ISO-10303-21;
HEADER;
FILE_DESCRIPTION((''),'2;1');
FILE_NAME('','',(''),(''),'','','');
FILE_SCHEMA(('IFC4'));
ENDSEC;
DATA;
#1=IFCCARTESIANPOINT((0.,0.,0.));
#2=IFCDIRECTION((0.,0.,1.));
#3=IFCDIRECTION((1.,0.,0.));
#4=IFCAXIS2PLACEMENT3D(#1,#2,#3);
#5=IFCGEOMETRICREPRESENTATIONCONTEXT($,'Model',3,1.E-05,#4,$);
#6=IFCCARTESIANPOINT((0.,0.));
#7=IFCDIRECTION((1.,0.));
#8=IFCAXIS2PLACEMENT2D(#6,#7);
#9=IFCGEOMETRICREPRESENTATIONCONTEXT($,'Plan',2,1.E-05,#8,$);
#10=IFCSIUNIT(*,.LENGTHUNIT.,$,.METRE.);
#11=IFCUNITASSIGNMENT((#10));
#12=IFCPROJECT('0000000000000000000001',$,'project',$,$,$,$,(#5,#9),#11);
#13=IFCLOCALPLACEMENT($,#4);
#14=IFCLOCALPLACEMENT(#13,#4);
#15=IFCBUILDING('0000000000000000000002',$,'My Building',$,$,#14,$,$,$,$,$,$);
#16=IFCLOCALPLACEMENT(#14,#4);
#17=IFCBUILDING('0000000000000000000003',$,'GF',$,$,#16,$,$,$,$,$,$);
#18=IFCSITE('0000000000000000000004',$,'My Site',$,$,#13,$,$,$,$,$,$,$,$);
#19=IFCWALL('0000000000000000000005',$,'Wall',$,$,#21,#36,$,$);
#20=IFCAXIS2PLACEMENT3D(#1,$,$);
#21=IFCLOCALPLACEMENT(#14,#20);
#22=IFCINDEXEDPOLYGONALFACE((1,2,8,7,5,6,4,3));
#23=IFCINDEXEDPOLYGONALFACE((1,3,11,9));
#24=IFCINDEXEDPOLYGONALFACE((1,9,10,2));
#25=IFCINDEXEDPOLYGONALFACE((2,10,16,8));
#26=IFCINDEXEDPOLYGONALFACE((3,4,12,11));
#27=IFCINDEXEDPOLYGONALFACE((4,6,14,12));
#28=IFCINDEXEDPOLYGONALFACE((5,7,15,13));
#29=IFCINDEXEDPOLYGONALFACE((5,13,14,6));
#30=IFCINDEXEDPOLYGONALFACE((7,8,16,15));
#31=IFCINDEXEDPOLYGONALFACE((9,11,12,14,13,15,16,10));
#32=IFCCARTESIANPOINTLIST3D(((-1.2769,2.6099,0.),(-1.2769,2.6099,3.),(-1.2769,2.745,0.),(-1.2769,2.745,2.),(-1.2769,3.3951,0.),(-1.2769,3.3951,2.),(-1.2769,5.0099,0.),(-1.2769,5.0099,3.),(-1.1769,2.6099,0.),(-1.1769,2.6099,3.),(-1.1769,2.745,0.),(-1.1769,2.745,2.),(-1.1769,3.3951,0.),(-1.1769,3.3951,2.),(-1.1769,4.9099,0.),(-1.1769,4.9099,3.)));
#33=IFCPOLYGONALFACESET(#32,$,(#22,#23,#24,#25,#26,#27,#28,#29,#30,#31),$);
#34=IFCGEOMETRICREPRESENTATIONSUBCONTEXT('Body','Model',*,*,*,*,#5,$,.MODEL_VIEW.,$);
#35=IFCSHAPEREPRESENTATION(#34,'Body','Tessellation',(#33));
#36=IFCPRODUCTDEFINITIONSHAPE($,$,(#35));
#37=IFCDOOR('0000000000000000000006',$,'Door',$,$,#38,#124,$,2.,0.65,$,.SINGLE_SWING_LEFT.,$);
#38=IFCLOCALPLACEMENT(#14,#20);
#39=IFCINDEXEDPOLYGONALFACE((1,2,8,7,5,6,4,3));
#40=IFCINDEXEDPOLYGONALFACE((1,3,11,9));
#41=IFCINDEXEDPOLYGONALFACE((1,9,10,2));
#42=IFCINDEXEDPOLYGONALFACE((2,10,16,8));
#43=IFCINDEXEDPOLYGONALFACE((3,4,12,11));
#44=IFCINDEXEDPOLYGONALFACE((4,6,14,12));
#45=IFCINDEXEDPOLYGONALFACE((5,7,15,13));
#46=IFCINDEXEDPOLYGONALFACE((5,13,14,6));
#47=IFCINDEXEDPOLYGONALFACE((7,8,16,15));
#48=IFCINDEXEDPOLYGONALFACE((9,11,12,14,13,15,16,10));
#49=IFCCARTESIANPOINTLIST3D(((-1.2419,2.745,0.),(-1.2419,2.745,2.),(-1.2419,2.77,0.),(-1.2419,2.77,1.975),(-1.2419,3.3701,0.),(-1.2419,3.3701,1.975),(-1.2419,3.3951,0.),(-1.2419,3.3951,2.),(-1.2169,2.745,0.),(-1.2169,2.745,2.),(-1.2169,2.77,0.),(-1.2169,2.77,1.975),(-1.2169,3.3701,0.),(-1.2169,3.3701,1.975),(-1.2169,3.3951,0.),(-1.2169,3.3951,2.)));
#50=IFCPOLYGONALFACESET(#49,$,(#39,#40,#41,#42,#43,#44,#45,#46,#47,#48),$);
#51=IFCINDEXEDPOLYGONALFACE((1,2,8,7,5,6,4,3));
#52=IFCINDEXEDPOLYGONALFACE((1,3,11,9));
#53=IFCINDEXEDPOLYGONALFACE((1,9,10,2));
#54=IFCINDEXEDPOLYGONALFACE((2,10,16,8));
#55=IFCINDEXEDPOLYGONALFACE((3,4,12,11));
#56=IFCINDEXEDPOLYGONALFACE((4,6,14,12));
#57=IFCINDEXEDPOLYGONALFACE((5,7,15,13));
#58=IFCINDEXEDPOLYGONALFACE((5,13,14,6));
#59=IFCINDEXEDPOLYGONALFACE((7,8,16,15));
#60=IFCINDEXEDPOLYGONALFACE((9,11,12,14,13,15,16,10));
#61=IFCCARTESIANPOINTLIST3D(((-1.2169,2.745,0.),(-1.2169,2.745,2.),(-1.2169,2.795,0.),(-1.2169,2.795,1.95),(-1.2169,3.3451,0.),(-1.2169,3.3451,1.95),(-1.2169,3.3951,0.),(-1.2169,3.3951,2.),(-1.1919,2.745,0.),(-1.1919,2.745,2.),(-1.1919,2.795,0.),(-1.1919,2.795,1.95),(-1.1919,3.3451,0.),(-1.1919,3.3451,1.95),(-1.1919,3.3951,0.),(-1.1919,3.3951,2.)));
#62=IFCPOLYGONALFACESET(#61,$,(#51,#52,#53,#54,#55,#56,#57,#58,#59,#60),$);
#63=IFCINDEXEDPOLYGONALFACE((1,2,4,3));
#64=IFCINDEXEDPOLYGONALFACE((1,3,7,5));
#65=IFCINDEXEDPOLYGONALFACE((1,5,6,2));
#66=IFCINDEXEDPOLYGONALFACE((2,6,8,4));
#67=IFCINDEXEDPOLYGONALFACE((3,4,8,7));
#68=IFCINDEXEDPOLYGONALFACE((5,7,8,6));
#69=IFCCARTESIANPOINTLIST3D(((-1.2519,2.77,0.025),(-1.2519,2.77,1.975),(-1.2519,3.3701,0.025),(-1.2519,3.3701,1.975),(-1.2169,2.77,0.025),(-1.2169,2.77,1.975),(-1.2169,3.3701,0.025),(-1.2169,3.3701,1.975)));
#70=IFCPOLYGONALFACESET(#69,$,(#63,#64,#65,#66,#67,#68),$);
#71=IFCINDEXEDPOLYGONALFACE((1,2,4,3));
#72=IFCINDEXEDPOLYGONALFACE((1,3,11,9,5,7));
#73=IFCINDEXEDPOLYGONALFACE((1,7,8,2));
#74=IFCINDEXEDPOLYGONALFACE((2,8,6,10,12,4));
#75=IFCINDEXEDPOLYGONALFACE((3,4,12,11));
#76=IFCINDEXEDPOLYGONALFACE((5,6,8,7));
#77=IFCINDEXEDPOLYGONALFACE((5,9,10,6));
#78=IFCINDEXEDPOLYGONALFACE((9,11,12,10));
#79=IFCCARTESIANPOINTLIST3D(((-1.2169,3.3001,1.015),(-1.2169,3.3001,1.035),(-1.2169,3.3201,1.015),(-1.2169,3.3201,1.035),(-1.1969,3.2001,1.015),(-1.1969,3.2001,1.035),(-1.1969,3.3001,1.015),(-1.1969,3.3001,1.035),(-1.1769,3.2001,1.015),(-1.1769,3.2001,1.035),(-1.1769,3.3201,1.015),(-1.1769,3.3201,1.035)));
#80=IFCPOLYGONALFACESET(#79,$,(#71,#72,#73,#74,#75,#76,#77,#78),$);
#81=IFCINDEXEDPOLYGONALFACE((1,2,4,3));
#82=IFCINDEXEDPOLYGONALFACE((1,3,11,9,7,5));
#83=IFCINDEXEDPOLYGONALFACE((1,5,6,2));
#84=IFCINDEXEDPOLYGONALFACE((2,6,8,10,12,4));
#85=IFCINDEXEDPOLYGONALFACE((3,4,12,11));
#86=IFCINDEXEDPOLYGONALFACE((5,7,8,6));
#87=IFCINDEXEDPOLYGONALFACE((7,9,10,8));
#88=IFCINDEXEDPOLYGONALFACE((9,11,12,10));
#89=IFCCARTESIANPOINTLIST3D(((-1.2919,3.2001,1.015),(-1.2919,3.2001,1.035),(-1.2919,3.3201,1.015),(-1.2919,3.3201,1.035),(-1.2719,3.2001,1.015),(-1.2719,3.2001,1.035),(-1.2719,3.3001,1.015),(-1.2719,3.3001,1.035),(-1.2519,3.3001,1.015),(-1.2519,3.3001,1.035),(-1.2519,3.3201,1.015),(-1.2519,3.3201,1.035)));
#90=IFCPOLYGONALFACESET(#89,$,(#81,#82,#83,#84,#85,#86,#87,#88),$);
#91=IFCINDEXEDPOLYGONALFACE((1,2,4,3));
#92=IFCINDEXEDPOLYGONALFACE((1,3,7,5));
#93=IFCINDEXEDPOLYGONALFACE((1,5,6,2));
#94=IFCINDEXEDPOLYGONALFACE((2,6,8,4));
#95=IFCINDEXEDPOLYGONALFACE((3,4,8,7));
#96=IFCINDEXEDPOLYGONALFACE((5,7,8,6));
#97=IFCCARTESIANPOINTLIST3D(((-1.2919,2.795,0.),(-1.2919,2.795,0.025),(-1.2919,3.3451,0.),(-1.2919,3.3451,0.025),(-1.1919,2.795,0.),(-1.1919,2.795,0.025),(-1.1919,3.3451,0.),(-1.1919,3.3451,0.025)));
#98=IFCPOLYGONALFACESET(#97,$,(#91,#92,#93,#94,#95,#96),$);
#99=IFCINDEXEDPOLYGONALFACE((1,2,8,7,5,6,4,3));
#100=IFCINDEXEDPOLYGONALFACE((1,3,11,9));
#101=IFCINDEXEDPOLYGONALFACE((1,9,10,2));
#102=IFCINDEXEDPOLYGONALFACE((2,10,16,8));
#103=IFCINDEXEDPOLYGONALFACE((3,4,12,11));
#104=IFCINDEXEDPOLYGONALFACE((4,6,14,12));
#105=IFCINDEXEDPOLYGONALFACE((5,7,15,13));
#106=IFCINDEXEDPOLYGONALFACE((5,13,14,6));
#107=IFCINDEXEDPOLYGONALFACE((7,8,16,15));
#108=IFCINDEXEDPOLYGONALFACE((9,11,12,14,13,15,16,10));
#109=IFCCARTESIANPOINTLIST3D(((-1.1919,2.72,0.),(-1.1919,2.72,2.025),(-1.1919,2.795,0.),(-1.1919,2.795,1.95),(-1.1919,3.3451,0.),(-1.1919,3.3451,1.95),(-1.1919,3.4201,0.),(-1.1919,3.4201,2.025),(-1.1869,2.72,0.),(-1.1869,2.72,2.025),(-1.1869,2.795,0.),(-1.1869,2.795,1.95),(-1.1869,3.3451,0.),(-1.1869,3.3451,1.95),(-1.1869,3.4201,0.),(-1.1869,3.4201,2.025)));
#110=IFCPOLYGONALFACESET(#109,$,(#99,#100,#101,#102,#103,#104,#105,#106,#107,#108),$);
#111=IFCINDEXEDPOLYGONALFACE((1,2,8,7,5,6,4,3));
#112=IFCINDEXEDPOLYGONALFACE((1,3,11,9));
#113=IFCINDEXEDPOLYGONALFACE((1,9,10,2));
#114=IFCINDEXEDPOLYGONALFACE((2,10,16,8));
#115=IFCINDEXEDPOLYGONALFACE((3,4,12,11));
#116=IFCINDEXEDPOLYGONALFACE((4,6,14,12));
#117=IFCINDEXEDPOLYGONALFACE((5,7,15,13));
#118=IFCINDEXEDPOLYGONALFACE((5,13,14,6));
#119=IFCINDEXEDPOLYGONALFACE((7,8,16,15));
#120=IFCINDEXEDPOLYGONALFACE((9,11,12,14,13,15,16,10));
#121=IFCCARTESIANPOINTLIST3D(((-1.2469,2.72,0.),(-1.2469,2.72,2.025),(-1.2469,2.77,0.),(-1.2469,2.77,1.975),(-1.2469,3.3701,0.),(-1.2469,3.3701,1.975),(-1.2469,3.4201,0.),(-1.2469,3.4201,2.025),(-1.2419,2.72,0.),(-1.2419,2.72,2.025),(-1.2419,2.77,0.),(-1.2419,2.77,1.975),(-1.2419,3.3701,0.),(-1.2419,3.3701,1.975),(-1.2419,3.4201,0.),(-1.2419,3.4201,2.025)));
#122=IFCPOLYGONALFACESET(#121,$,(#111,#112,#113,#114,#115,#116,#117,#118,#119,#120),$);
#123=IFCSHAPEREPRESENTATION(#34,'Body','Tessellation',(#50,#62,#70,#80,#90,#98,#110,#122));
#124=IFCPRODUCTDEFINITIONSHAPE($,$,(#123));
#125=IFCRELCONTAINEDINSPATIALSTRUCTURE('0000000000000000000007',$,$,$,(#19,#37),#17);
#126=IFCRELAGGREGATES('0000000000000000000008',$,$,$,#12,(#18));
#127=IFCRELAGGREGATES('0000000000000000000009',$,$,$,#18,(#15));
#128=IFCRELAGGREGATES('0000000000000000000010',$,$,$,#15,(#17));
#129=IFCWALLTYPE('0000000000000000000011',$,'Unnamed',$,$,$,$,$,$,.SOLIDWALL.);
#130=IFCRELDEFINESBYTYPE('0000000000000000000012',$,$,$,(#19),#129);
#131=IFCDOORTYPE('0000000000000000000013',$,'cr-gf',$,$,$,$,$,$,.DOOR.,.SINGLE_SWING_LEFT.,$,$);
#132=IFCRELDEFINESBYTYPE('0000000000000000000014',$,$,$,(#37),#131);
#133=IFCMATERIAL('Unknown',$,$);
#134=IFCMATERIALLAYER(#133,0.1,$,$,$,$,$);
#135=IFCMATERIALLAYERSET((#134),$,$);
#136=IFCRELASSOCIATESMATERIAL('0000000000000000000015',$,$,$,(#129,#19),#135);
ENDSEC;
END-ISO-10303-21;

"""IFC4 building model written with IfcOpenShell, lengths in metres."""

from ifc_helpers import new_model, entity, si_unit, frame, origin_with_axes, origin_2d_with_axis, place, context, subcontext, project, spatial, line, indexed_curve, outline, extrude, shape, source, transform, mapped, material, layer, layer_set, layer_usage, type_object, type_shapes, element, fill, save


model = new_model("IFC4")

# Units and contexts
model_context = context("Model", 3, precision=1e-05, world=origin_with_axes())
plan_context = context("Plan", 2, precision=1e-05, world=origin_2d_with_axis())
body_context_1 = subcontext(model_context, "Body", "Model", "MODEL_VIEW")
body_context_2 = subcontext(plan_context, "Body", "Plan", "PLAN_VIEW")
ifc_project = project(units=[si_unit("LENGTHUNIT", "METRE")], contexts=[model_context, plan_context])

# Site, buildings
site_placement = place(None, origin_with_axes())
site = spatial("IfcSite", under=ifc_project, at=site_placement, Name="My Site")
building_1_placement = place(site_placement, origin_with_axes())
building_1 = spatial("IfcBuilding", under=site, at=building_1_placement, Name="My Building")
building_2_placement = place(building_1_placement, origin_with_axes())
building_2 = spatial("IfcBuilding", under=building_1, at=building_2_placement, Name="GF")

# Shared definitions
ifc_material = material(Name="Unknown")

# Shared definitions
ifc_layer_1 = layer(ifc_material, 0.1)
ifc_layer_set_1 = layer_set([ifc_layer_1])
wall_type = type_object("IfcWallType", Name="Unnamed", PredefinedType="SOLIDWALL", material=ifc_layer_set_1)

# Wall, opening, door
ifc_layer_usage_1 = layer_usage(ifc_layer_set_1, "AXIS2", "POSITIVE", 0.0)
wall_1_placement = place(building_2_placement, frame((-1.1769, 2.6099, 0.0), z_axis=(0.0, 0.0, 1.0), x_axis=(0.0, 1.0, 0.0)))
wall_1 = element("IfcWall", 1, at=wall_1_placement, inside=building_2, type_object=wall_type, material=ifc_layer_usage_1, Name="Wall", context=body_context_1, shape_type="SweptSolid", body=[
    extrude(outline(indexed_curve([(0.0, 0.0), (0.0, 0.1), (2.4, 0.1), (2.3, 0.0)], segments=[line(1, 2, 3, 4, 1)])), origin_with_axes(), (0.0, 0.0, 1.0), 3.0),
])
shared_shape_1 = source(origin_with_axes(), body_context_1, "Body", "SweptSolid", [
    extrude(outline(indexed_curve([(0.0, 0.0), (0.65, 0.0), (0.65, 2.0), (0.0, 2.0)], segments=[line(1, 2, 3, 4, 1)])), frame((0.0, -0.6, 0.0), z_axis=(0.0, -1.0, 0.0), x_axis=(1.0, 0.0, 0.0)), (0.0, 0.0, -1.0), 1.2),
])
opening_1_placement = place(wall_1_placement, frame((0.1352, 0.015, 0.0), z_axis=(0.0, 0.0, 1.0), x_axis=(1.0, 0.0, 0.0)))
opening_1 = element("IfcOpeningElement", 2, at=opening_1_placement, cuts=wall_1, PredefinedType="OPENING", context=body_context_1, shape_type="MappedRepresentation", body=[
    mapped(shared_shape_1, transform((0.0, 0.0, 0.0), x_axis=(1.0, 0.0, 0.0), y_axis=(0.0, 1.0, 0.0), z_axis=(0.0, 0.0, 1.0), scale=1.0)),
])
door_type_1 = type_object("IfcDoorType", Name="cr-gf", OperationType="SINGLE_SWING_LEFT", PredefinedType="DOOR")
shared_shape_2 = source(origin_with_axes(), body_context_1, "Body", "SweptSolid", [
    extrude(outline(indexed_curve([(0.0, 0.0), (0.0, 2.0), (0.65, 2.0), (0.65, 0.0), (0.625, 0.0), (0.625, 1.975), (0.025, 1.975), (0.025, 0.0)], segments=[line(1, 2, 3, 4, 5, 6, 7, 8, 1)])), frame((0.0, 0.025, 0.0), z_axis=(0.0, -1.0, 0.0), x_axis=(1.0, 0.0, 0.0)), (0.0, 0.0, -1.0), 0.025),
    extrude(outline(indexed_curve([(0.0, 0.0), (0.0, 2.0), (0.65, 2.0), (0.65, 0.0), (0.6, 0.0), (0.6, 1.95), (0.05, 1.95), (0.05, 0.0)], segments=[line(1, 2, 3, 4, 5, 6, 7, 8, 1)])), frame((0.0, 0.0, 0.0), z_axis=(0.0, -1.0, 0.0), x_axis=(1.0, 0.0, 0.0)), (0.0, 0.0, -1.0), 0.025),
    extrude(outline(indexed_curve([(0.0, 0.0), (0.6, 0.0), (0.6, 0.035), (0.0, 0.035)], segments=[line(1, 2, 3, 4, 1)])), frame((0.025, 0.025, 0.025), z_axis=(0.0, 0.0, 1.0), x_axis=(1.0, 0.0, 0.0)), (0.0, 0.0, 1.0), 1.95),
    extrude(outline(indexed_curve([(0.0, 0.0), (0.0, -0.04), (-0.12, -0.04), (-0.12, -0.02), (-0.02, -0.02), (-0.02, 0.0)], segments=[line(1, 2, 3, 4, 5, 6, 1)])), frame((0.575, 0.025, 1.015), z_axis=(0.0, 0.0, 1.0), x_axis=(1.0, 0.0, 0.0)), (0.0, 0.0, 1.0), 0.02),
    extrude(outline(indexed_curve([(0.0, 0.0), (0.0, 0.04), (-0.12, 0.04), (-0.12, 0.02), (-0.02, 0.02), (-0.02, 0.0)], segments=[line(1, 2, 3, 4, 5, 6, 1)])), frame((0.575, 0.06, 1.015), z_axis=(0.0, 0.0, 1.0), x_axis=(1.0, 0.0, 0.0)), (0.0, 0.0, 1.0), 0.02),
    extrude(outline(indexed_curve([(0.0, 0.0), (0.55, 0.0), (0.55, 0.1), (0.0, 0.1)], segments=[line(1, 2, 3, 4, 1)])), frame((0.05, 0.0, 0.0), z_axis=(0.0, 0.0, 1.0), x_axis=(1.0, 0.0, 0.0)), (0.0, 0.0, 1.0), 0.025),
    extrude(outline(indexed_curve([(0.0, 0.0), (0.0, 2.025), (0.7, 2.025), (0.7, 0.0), (0.625, 0.0), (0.625, 1.95), (0.075, 1.95), (0.075, 0.0)], segments=[line(1, 2, 3, 4, 5, 6, 7, 8, 1)])), frame((-0.025, -0.005, 0.0), z_axis=(0.0, -1.0, 0.0), x_axis=(1.0, 0.0, 0.0)), (0.0, 0.0, -1.0), 0.005),
    extrude(outline(indexed_curve([(0.0, 0.0), (0.0, 2.025), (0.7, 2.025), (0.7, 0.0), (0.65, 0.0), (0.65, 1.975), (0.05, 1.975), (0.05, 0.0)], segments=[line(1, 2, 3, 4, 5, 6, 7, 8, 1)])), frame((-0.025, 0.05, 0.0), z_axis=(0.0, -1.0, 0.0), x_axis=(1.0, 0.0, 0.0)), (0.0, 0.0, -1.0), 0.005),
])
shared_shape_3 = source(origin_with_axes(), body_context_2, "Body", "Curve2D", [
    entity("IfcIndexedPolyCurve", entity("IfcCartesianPointList2D", [[0.0, 0.0], [0.0, 0.05], [0.025, 0.05], [0.025, 0.025], [0.05, 0.025], [0.05, 0.0]]), [entity("IfcLineIndex", [1, 2, 3, 4, 5, 6, 1])]),
    entity("IfcIndexedPolyCurve", entity("IfcCartesianPointList2D", [[0.65, 0.0], [0.65, 0.05], [0.625, 0.05], [0.625, 0.025], [0.6, 0.025], [0.6, 0.0]]), [entity("IfcLineIndex", [1, 2, 3, 4, 5, 6, 1])]),
    entity("IfcTrimmedCurve", entity("IfcEllipse", entity("IfcAxis2Placement2D", entity("IfcCartesianPoint", [0.06, 0.05]), entity("IfcDirection", [1.0, 0.0])), 0.565, 0.6), [entity("IfcCartesianPoint", [0.625, 0.05])], [entity("IfcCartesianPoint", [0.06, 0.65])], True, "CARTESIAN"),
    entity("IfcIndexedPolyCurve", entity("IfcCartesianPointList2D", [[0.025, 0.05], [0.06, 0.05], [0.06, 0.65], [0.025, 0.65]]), [entity("IfcLineIndex", [1, 2, 3, 4, 1])]),
])
type_shapes(door_type_1, [shared_shape_2, shared_shape_3])
door_1_placement = place(opening_1_placement, frame((0.0, 0.0, 0.0), z_axis=(0.0, 0.0, 1.0), x_axis=(1.0, 0.0, 0.0)))
door_1 = element("IfcDoor", 3, at=door_1_placement, inside=building_2, type_object=door_type_1, Name="Door", OperationType="SINGLE_SWING_LEFT", OverallHeight=2.0, OverallWidth=0.65, shapes=[
    shape(body_context_1, "Body", "MappedRepresentation", [mapped(shared_shape_2, transform((0.0, 0.0, 0.0), x_axis=(1.0, 0.0, 0.0), y_axis=(0.0, 1.0, 0.0), z_axis=(0.0, 0.0, 1.0), scale=1.0))]),
    shape(body_context_2, "Body", "MappedRepresentation", [mapped(shared_shape_3, transform((0.0, 0.0, 0.0), x_axis=(1.0, 0.0, 0.0), y_axis=(0.0, 1.0, 0.0), z_axis=(0.0, 0.0, 1.0), scale=1.0))]),
])
fill(opening_1, door_1)

save(model, "model.ifc")
